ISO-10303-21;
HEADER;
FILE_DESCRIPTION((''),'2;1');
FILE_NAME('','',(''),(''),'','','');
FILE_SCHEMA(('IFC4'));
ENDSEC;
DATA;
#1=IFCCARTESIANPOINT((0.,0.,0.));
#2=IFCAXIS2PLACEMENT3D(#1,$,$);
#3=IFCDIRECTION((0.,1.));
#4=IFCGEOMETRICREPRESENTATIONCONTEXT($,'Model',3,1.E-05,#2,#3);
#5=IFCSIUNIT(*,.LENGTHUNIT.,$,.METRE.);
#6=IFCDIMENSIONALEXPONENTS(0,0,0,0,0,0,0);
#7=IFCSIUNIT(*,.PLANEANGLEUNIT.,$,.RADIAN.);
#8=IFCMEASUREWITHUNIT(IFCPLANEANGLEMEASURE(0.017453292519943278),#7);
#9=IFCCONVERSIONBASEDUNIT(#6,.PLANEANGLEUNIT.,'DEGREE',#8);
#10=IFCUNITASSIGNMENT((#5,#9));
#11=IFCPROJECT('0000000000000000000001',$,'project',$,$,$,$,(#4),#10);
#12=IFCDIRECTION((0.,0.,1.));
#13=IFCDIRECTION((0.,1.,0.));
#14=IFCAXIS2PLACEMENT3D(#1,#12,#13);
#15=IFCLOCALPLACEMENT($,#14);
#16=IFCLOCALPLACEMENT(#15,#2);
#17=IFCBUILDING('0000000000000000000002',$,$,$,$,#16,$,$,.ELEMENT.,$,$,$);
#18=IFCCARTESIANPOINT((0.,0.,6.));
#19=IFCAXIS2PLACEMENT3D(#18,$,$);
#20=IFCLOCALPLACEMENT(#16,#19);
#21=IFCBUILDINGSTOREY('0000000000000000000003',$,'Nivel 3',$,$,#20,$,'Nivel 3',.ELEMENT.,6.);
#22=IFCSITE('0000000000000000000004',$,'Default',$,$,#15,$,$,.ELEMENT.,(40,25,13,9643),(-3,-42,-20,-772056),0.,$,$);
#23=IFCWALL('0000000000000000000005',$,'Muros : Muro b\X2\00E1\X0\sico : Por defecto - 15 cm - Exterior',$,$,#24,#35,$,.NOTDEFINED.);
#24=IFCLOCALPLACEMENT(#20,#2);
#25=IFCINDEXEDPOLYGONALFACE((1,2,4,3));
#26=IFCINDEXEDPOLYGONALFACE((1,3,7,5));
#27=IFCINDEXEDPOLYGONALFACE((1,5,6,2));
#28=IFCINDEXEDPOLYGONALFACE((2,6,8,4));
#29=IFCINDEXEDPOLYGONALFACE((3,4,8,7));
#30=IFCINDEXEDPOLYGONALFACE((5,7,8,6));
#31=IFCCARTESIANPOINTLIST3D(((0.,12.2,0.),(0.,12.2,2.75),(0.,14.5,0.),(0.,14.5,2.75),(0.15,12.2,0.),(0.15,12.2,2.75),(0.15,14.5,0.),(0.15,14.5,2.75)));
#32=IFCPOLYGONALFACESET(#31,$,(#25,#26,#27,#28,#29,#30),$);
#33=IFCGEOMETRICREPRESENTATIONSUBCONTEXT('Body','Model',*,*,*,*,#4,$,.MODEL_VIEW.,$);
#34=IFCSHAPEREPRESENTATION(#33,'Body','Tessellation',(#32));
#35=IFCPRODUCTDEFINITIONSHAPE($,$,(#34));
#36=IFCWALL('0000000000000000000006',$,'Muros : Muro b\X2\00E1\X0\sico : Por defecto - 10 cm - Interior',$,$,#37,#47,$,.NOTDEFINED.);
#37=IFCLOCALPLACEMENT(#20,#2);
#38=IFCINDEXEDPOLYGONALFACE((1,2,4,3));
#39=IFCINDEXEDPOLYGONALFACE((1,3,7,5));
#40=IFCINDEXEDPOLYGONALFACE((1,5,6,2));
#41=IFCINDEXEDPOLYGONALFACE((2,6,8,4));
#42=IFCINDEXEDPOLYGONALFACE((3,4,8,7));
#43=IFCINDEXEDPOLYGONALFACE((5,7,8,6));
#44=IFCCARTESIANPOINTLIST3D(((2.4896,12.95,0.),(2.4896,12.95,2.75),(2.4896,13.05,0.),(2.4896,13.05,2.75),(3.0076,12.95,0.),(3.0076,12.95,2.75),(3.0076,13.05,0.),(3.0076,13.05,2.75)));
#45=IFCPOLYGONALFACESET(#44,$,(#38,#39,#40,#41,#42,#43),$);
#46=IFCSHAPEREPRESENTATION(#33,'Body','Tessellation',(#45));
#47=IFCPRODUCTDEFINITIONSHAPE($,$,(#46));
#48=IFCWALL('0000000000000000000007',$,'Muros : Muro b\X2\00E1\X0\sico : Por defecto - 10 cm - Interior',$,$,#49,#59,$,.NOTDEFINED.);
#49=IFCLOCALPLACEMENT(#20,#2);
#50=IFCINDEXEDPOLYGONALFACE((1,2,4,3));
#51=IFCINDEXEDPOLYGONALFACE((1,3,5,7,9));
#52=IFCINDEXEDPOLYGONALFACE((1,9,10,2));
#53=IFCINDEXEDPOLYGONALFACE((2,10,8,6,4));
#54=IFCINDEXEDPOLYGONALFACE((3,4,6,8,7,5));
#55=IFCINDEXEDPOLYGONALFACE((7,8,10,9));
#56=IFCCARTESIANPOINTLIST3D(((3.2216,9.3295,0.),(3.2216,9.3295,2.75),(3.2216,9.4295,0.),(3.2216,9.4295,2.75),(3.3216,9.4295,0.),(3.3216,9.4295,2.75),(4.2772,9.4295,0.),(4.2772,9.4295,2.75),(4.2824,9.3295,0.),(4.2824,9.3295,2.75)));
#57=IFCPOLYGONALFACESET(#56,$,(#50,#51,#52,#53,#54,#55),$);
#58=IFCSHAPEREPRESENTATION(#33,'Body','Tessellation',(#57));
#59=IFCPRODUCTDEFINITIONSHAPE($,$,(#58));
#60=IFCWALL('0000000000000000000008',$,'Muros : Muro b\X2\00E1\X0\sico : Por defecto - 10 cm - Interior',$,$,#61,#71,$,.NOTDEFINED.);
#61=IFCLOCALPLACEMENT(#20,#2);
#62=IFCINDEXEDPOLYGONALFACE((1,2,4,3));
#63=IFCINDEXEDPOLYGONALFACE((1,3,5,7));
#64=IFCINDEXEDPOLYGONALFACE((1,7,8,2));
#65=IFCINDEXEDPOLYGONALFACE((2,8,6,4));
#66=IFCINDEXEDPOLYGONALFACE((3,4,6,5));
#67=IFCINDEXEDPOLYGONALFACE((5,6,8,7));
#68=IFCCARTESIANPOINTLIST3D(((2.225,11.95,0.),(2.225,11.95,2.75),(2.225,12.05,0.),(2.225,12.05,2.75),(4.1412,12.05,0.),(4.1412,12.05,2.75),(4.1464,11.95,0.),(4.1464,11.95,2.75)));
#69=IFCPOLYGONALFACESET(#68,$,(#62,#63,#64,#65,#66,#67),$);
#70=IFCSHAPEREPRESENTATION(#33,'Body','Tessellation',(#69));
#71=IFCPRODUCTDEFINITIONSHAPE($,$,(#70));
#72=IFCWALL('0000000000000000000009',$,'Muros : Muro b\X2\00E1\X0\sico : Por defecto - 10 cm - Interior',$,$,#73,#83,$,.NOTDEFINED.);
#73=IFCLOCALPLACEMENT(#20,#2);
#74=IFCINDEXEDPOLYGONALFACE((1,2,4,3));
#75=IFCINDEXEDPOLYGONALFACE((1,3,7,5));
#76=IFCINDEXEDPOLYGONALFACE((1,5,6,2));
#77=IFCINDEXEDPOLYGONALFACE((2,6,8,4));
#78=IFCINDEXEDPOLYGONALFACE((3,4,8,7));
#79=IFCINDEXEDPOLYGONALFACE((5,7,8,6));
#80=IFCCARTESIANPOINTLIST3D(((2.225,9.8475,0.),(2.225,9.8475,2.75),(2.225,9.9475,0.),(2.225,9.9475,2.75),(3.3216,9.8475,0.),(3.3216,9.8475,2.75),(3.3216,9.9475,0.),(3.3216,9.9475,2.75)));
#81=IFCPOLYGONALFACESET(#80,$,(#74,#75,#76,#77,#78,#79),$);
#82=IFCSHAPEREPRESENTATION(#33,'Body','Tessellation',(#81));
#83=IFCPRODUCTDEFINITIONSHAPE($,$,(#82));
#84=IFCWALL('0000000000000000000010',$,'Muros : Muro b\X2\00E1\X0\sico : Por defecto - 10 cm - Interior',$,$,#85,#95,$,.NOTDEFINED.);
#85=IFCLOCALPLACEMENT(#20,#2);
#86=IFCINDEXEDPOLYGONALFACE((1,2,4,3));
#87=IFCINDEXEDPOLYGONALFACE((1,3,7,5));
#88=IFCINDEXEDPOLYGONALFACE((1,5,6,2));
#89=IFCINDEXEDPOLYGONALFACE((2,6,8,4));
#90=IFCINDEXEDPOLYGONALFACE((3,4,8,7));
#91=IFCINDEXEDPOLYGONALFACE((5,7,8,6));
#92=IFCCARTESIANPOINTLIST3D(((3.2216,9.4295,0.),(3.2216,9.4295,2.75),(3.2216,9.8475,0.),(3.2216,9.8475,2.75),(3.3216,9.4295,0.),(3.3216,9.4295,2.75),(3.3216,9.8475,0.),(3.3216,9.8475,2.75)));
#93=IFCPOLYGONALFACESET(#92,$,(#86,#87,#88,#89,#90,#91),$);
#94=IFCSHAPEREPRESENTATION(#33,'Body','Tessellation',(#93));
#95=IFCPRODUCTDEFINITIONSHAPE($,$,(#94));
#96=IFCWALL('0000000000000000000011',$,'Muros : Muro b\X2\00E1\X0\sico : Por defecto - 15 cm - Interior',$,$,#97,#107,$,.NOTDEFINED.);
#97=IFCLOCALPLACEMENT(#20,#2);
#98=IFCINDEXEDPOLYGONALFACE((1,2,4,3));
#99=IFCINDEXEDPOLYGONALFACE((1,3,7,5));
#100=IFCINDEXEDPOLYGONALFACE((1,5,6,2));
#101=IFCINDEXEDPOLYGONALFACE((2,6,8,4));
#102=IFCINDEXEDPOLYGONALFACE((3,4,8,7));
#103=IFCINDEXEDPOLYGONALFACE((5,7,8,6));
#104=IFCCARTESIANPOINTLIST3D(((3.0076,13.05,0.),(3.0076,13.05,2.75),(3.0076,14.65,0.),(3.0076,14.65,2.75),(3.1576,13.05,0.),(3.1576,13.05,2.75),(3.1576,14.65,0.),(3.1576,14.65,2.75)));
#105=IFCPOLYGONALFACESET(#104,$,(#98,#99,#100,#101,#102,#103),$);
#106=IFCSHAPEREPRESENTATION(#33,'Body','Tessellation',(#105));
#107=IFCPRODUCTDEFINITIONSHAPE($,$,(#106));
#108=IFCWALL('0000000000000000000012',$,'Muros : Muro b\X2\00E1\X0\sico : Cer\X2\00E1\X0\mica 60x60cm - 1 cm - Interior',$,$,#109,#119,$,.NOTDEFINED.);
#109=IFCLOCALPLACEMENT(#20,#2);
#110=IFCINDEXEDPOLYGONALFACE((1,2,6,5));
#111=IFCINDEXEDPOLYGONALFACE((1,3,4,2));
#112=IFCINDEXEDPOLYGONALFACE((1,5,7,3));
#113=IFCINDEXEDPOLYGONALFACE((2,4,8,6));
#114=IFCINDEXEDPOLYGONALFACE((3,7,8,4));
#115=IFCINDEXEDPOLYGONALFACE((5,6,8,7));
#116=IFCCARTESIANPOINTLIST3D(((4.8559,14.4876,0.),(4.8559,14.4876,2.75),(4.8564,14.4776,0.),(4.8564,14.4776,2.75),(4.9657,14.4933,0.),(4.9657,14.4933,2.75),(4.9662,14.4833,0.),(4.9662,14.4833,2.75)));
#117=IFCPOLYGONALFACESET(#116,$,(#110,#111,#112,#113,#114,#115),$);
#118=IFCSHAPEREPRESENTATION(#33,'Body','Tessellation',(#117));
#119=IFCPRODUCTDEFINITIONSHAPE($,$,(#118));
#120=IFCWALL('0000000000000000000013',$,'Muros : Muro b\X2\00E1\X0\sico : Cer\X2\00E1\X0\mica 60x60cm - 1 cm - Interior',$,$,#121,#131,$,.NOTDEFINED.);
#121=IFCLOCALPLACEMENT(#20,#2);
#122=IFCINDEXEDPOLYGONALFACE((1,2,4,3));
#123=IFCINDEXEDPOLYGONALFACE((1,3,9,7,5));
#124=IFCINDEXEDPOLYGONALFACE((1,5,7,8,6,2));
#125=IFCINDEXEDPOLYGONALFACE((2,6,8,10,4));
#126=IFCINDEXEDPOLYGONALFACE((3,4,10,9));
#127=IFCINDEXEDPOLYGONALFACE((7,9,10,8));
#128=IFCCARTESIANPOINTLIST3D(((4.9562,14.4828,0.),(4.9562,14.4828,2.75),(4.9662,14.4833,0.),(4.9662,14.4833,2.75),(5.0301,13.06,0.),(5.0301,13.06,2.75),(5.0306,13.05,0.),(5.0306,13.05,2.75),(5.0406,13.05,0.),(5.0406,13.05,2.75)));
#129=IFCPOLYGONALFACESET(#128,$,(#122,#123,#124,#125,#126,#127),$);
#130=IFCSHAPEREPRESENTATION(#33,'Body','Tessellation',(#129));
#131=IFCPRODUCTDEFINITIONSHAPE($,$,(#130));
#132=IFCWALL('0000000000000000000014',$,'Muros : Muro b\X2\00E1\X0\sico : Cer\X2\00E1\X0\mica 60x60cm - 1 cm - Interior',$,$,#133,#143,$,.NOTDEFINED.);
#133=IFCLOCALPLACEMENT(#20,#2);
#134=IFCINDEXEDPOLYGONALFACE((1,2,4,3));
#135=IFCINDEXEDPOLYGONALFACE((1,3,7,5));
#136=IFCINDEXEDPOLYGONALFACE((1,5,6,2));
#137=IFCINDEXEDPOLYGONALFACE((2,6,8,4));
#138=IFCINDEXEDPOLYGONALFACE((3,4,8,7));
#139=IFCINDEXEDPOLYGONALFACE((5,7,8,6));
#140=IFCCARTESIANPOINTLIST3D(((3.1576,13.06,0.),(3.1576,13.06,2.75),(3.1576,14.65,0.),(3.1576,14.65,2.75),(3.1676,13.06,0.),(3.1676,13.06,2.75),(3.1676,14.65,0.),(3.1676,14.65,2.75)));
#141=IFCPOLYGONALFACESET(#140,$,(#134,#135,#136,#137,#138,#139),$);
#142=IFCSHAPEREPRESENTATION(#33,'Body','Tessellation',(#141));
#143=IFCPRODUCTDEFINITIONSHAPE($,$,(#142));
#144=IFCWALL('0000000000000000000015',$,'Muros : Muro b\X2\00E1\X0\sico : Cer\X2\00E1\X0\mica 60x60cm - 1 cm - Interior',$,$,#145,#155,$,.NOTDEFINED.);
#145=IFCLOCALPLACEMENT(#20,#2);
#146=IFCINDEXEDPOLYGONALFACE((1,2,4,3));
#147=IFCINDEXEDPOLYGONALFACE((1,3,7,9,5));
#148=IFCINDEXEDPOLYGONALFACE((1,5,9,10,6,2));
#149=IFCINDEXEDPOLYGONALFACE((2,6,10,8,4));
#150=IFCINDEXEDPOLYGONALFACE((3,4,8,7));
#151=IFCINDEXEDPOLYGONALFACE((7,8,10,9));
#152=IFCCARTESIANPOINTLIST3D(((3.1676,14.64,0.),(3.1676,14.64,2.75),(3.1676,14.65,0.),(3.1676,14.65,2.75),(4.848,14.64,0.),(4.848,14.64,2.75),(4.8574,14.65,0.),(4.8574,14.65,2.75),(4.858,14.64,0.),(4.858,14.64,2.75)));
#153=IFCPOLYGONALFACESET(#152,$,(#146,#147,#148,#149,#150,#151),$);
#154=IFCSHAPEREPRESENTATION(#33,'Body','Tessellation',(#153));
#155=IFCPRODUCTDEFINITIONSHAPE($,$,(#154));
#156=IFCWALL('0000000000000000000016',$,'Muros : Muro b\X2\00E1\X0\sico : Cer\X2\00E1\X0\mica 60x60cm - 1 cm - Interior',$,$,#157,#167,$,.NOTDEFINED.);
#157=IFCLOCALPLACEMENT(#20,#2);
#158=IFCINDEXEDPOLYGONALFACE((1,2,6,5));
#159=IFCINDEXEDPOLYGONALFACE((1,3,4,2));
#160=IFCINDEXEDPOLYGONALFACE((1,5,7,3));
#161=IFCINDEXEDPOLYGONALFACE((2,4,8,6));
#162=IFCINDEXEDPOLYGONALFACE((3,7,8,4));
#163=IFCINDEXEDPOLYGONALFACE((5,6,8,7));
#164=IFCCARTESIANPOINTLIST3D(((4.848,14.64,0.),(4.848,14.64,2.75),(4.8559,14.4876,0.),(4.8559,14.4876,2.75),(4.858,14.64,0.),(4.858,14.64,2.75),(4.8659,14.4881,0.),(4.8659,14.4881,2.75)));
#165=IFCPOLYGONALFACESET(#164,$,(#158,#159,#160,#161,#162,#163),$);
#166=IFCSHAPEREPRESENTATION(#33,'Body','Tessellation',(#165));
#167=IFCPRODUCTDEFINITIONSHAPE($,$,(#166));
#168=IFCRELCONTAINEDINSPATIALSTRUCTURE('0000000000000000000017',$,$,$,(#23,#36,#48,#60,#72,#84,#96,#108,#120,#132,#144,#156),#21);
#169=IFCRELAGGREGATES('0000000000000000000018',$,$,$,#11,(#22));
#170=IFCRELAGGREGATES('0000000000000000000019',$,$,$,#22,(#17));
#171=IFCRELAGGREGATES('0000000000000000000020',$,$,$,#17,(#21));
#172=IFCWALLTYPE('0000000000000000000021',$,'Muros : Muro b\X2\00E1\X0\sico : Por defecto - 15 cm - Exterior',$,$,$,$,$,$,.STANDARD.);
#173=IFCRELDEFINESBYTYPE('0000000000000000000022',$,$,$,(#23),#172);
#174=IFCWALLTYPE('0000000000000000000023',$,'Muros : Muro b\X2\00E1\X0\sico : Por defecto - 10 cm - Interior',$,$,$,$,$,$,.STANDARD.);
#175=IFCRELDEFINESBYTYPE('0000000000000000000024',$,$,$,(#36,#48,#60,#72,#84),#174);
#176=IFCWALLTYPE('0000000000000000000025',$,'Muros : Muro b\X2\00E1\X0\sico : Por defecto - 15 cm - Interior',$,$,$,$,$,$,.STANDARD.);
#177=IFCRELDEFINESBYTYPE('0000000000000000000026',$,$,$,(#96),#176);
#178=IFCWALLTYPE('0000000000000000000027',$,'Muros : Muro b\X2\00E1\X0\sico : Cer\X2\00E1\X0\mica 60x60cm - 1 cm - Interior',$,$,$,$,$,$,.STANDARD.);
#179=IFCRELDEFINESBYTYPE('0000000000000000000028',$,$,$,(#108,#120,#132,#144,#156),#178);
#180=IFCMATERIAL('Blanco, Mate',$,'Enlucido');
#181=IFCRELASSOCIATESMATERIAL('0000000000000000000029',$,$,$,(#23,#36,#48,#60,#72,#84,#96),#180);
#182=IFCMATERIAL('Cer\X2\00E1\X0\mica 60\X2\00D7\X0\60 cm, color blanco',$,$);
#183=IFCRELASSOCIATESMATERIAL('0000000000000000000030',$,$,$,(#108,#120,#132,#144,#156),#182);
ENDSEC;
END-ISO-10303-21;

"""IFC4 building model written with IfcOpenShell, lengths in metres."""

from ifc_helpers import new_model, entity, si_unit, converted_unit, direction, frame, origin, place, context, subcontext, project, spatial, indexed_curve, outline, extrude, material, type_object, element, save


model = new_model("IFC4")

# Units and contexts
model_context = context("Model", 3, precision=1e-05, world=origin(), true_north=direction((0.0, 1.0)))
body_context = subcontext(model_context, "Body", "Model", "MODEL_VIEW")
ifc_project = project(units=[si_unit("LENGTHUNIT", "METRE"), converted_unit("PLANEANGLEUNIT", "DEGREE", entity("IfcPlaneAngleMeasure", 0.017453292519943278), si_unit("PLANEANGLEUNIT", "RADIAN"), dimensions=[0, 0, 0, 0, 0, 0, 0])], contexts=[model_context])

# Site, building, storey
site_placement = place(None, frame((0.0, 0.0, 0.0), z_axis=(0.0, 0.0, 1.0), x_axis=(0.0, 1.0, 0.0)))
site = spatial("IfcSite", under=ifc_project, at=site_placement, Name="Default", CompositionType="ELEMENT", RefLatitude=(40, 25, 13, 9643), RefLongitude=(-3, -42, -20, -772056), RefElevation=0.0)
building_placement = place(site_placement, origin())
building = spatial("IfcBuilding", under=site, at=building_placement, CompositionType="ELEMENT")
storey_placement = place(building_placement, frame((0.0, 0.0, 6.0)))
storey = spatial("IfcBuildingStorey", under=building, at=storey_placement, Name="Nivel 3", LongName="Nivel 3", CompositionType="ELEMENT", Elevation=6.0)

# Shared definitions
ifc_material_1 = material(Name="Blanco, Mate", Category="Enlucido")

# Walls
wall_type_1 = type_object("IfcWallType", Name="Muros : Muro básico : Por defecto - 15 cm - Exterior", PredefinedType="STANDARD")
wall_1_placement = place(storey_placement, frame((0.075, 12.2, 0.0), z_axis=(0.0, 0.0, 1.0), x_axis=(0.0, 1.0, 0.0)))
element("IfcWall", 1, at=wall_1_placement, inside=storey, type_object=wall_type_1, material=ifc_material_1, Name="Muros : Muro básico : Por defecto - 15 cm - Exterior", PredefinedType="NOTDEFINED", context=body_context, shape_type="SweptSolid", body=[
    extrude(outline(indexed_curve([(2.3, 0.075), (0.0, 0.075), (0.0, -0.075), (2.3, -0.075), (2.3, 0.075)], self_intersect=False)), origin(), (0.0, 0.0, 1.0), 2.75),
])
wall_type_2 = type_object("IfcWallType", Name="Muros : Muro básico : Por defecto - 10 cm - Interior", PredefinedType="STANDARD")
wall_2_placement = place(storey_placement, frame((3.0076, 13.0, 0.0), z_axis=(0.0, 0.0, 1.0), x_axis=(-1.0, 0.0, 0.0)))
element("IfcWall", 2, at=wall_2_placement, inside=storey, type_object=wall_type_2, material=ifc_material_1, Name="Muros : Muro básico : Por defecto - 10 cm - Interior", PredefinedType="NOTDEFINED", context=body_context, shape_type="SweptSolid", body=[
    extrude(outline(indexed_curve([(0.518, 0.05), (0.0, 0.05), (0.0, -0.05), (0.518, -0.05), (0.518, 0.05)], self_intersect=False)), origin(), (0.0, 0.0, 1.0), 2.75),
])
wall_3_placement = place(storey_placement, frame((4.2824, 9.3795, 0.0), z_axis=(0.0, 0.0, 1.0), x_axis=(-1.0, 0.0, 0.0)))
element("IfcWall", 3, at=wall_3_placement, inside=storey, type_object=wall_type_2, material=ifc_material_1, Name="Muros : Muro básico : Por defecto - 10 cm - Interior", PredefinedType="NOTDEFINED", context=body_context, shape_type="SweptSolid", body=[
    extrude(outline(indexed_curve([(1.0608, -0.05), (1.0608, 0.05), (0.0, 0.05), (0.0052, -0.05), (0.9608, -0.05), (1.0608, -0.05)], self_intersect=False)), origin(), (0.0, 0.0, 1.0), 2.75),
])
wall_4_placement = place(storey_placement, frame((2.225, 12.0, 0.0)))
element("IfcWall", 4, at=wall_4_placement, inside=storey, type_object=wall_type_2, material=ifc_material_1, Name="Muros : Muro básico : Por defecto - 10 cm - Interior", PredefinedType="NOTDEFINED", context=body_context, shape_type="SweptSolid", body=[
    extrude(outline(indexed_curve([(1.9214, -0.05), (1.9162, 0.05), (0.0, 0.05), (0.0, -0.05), (1.9214, -0.05)], self_intersect=False)), origin(), (0.0, 0.0, 1.0), 2.75),
])
wall_5_placement = place(storey_placement, frame((3.3216, 9.8975, 0.0), z_axis=(0.0, 0.0, 1.0), x_axis=(-1.0, 0.0, 0.0)))
element("IfcWall", 5, at=wall_5_placement, inside=storey, type_object=wall_type_2, material=ifc_material_1, Name="Muros : Muro básico : Por defecto - 10 cm - Interior", PredefinedType="NOTDEFINED", context=body_context, shape_type="SweptSolid", body=[
    extrude(outline(indexed_curve([(1.0966, 0.05), (0.0, 0.05), (0.0, -0.05), (1.0966, -0.05), (1.0966, 0.05)], self_intersect=False)), origin(), (0.0, 0.0, 1.0), 2.75),
])
wall_6_placement = place(storey_placement, frame((3.2716, 9.4295, 0.0), z_axis=(0.0, 0.0, 1.0), x_axis=(0.0, 1.0, 0.0)))
element("IfcWall", 6, at=wall_6_placement, inside=storey, type_object=wall_type_2, material=ifc_material_1, Name="Muros : Muro básico : Por defecto - 10 cm - Interior", PredefinedType="NOTDEFINED", context=body_context, shape_type="SweptSolid", body=[
    extrude(outline(indexed_curve([(0.418, 0.05), (0.0, 0.05), (0.0, -0.05), (0.418, -0.05), (0.418, 0.05)], self_intersect=False)), origin(), (0.0, 0.0, 1.0), 2.75),
])
wall_type_3 = type_object("IfcWallType", Name="Muros : Muro básico : Por defecto - 15 cm - Interior", PredefinedType="STANDARD")
wall_7_placement = place(storey_placement, frame((3.0826, 14.65, 0.0), z_axis=(0.0, 0.0, 1.0), x_axis=(0.0, -1.0, 0.0)))
element("IfcWall", 7, at=wall_7_placement, inside=storey, type_object=wall_type_3, material=ifc_material_1, Name="Muros : Muro básico : Por defecto - 15 cm - Interior", PredefinedType="NOTDEFINED", context=body_context, shape_type="SweptSolid", body=[
    extrude(outline(indexed_curve([(1.6, 0.075), (0.0, 0.075), (0.0, -0.075), (1.6, -0.075), (1.6, 0.075)], self_intersect=False)), origin(), (0.0, 0.0, 1.0), 2.75),
])
ifc_material_2 = material(Name="Cerámica 60×60 cm, color blanco")
wall_type_4 = type_object("IfcWallType", Name="Muros : Muro básico : Cerámica 60x60cm - 1 cm - Interior", PredefinedType="STANDARD")
wall_8_placement = place(storey_placement, frame((4.8561, 14.4826, 0.0), z_axis=(0.0, 0.0, 1.0), x_axis=(0.998656, 0.051826, 0.0)))
element("IfcWall", 8, at=wall_8_placement, inside=storey, type_object=wall_type_4, material=ifc_material_2, Name="Muros : Muro básico : Cerámica 60x60cm - 1 cm - Interior", PredefinedType="NOTDEFINED", context=body_context, shape_type="SweptSolid", body=[
    extrude(outline(indexed_curve([(0.11, 0.005), (0.0, 0.005), (0.0, -0.005), (0.11, -0.005), (0.11, 0.005)], self_intersect=False)), origin(), (0.0, 0.0, 1.0), 2.75),
])
wall_9_placement = place(storey_placement, frame((4.9612, 14.483, 0.0), z_axis=(0.0, 0.0, 1.0), x_axis=(0.051826, -0.998656, 0.0)))
element("IfcWall", 9, at=wall_9_placement, inside=storey, type_object=wall_type_4, material=ifc_material_2, Name="Muros : Muro básico : Cerámica 60x60cm - 1 cm - Interior", PredefinedType="NOTDEFINED", context=body_context, shape_type="SweptSolid", body=[
    extrude(outline(indexed_curve([(1.4347, -0.005), (1.4352, 0.005), (0.0, 0.005), (0.0, -0.005), (1.4247, -0.005), (1.4347, -0.005)], self_intersect=False)), origin(), (0.0, 0.0, 1.0), 2.75),
])
wall_10_placement = place(storey_placement, frame((3.1626, 13.06, 0.0), z_axis=(0.0, 0.0, 1.0), x_axis=(0.0, 1.0, 0.0)))
element("IfcWall", 10, at=wall_10_placement, inside=storey, type_object=wall_type_4, material=ifc_material_2, Name="Muros : Muro básico : Cerámica 60x60cm - 1 cm - Interior", PredefinedType="NOTDEFINED", context=body_context, shape_type="SweptSolid", body=[
    extrude(outline(indexed_curve([(1.59, 0.005), (0.0, 0.005), (0.0, -0.005), (1.59, -0.005), (1.59, 0.005)], self_intersect=False)), origin(), (0.0, 0.0, 1.0), 2.75),
])
wall_11_placement = place(storey_placement, frame((3.1676, 14.645, 0.0)))
element("IfcWall", 11, at=wall_11_placement, inside=storey, type_object=wall_type_4, material=ifc_material_2, Name="Muros : Muro básico : Cerámica 60x60cm - 1 cm - Interior", PredefinedType="NOTDEFINED", context=body_context, shape_type="SweptSolid", body=[
    extrude(outline(indexed_curve([(1.6904, -0.005), (1.6899, 0.005), (0.0, 0.005), (0.0, -0.005), (1.6804, -0.005), (1.6904, -0.005)], self_intersect=False)), origin(), (0.0, 0.0, 1.0), 2.75),
])
wall_12_placement = place(storey_placement, frame((4.8529, 14.6403, 0.0), z_axis=(0.0, 0.0, 1.0), x_axis=(0.051826, -0.998656, 0.0)))
element("IfcWall", 12, at=wall_12_placement, inside=storey, type_object=wall_type_4, material=ifc_material_2, Name="Muros : Muro básico : Cerámica 60x60cm - 1 cm - Interior", PredefinedType="NOTDEFINED", context=body_context, shape_type="SweptSolid", body=[
    extrude(outline(indexed_curve([(0.1526, -0.005), (0.1526, 0.005), (0.0005, 0.005), (0.0, -0.005), (0.1526, -0.005)], self_intersect=False)), origin(), (0.0, 0.0, 1.0), 2.75),
])

save(model, "model.ifc")
